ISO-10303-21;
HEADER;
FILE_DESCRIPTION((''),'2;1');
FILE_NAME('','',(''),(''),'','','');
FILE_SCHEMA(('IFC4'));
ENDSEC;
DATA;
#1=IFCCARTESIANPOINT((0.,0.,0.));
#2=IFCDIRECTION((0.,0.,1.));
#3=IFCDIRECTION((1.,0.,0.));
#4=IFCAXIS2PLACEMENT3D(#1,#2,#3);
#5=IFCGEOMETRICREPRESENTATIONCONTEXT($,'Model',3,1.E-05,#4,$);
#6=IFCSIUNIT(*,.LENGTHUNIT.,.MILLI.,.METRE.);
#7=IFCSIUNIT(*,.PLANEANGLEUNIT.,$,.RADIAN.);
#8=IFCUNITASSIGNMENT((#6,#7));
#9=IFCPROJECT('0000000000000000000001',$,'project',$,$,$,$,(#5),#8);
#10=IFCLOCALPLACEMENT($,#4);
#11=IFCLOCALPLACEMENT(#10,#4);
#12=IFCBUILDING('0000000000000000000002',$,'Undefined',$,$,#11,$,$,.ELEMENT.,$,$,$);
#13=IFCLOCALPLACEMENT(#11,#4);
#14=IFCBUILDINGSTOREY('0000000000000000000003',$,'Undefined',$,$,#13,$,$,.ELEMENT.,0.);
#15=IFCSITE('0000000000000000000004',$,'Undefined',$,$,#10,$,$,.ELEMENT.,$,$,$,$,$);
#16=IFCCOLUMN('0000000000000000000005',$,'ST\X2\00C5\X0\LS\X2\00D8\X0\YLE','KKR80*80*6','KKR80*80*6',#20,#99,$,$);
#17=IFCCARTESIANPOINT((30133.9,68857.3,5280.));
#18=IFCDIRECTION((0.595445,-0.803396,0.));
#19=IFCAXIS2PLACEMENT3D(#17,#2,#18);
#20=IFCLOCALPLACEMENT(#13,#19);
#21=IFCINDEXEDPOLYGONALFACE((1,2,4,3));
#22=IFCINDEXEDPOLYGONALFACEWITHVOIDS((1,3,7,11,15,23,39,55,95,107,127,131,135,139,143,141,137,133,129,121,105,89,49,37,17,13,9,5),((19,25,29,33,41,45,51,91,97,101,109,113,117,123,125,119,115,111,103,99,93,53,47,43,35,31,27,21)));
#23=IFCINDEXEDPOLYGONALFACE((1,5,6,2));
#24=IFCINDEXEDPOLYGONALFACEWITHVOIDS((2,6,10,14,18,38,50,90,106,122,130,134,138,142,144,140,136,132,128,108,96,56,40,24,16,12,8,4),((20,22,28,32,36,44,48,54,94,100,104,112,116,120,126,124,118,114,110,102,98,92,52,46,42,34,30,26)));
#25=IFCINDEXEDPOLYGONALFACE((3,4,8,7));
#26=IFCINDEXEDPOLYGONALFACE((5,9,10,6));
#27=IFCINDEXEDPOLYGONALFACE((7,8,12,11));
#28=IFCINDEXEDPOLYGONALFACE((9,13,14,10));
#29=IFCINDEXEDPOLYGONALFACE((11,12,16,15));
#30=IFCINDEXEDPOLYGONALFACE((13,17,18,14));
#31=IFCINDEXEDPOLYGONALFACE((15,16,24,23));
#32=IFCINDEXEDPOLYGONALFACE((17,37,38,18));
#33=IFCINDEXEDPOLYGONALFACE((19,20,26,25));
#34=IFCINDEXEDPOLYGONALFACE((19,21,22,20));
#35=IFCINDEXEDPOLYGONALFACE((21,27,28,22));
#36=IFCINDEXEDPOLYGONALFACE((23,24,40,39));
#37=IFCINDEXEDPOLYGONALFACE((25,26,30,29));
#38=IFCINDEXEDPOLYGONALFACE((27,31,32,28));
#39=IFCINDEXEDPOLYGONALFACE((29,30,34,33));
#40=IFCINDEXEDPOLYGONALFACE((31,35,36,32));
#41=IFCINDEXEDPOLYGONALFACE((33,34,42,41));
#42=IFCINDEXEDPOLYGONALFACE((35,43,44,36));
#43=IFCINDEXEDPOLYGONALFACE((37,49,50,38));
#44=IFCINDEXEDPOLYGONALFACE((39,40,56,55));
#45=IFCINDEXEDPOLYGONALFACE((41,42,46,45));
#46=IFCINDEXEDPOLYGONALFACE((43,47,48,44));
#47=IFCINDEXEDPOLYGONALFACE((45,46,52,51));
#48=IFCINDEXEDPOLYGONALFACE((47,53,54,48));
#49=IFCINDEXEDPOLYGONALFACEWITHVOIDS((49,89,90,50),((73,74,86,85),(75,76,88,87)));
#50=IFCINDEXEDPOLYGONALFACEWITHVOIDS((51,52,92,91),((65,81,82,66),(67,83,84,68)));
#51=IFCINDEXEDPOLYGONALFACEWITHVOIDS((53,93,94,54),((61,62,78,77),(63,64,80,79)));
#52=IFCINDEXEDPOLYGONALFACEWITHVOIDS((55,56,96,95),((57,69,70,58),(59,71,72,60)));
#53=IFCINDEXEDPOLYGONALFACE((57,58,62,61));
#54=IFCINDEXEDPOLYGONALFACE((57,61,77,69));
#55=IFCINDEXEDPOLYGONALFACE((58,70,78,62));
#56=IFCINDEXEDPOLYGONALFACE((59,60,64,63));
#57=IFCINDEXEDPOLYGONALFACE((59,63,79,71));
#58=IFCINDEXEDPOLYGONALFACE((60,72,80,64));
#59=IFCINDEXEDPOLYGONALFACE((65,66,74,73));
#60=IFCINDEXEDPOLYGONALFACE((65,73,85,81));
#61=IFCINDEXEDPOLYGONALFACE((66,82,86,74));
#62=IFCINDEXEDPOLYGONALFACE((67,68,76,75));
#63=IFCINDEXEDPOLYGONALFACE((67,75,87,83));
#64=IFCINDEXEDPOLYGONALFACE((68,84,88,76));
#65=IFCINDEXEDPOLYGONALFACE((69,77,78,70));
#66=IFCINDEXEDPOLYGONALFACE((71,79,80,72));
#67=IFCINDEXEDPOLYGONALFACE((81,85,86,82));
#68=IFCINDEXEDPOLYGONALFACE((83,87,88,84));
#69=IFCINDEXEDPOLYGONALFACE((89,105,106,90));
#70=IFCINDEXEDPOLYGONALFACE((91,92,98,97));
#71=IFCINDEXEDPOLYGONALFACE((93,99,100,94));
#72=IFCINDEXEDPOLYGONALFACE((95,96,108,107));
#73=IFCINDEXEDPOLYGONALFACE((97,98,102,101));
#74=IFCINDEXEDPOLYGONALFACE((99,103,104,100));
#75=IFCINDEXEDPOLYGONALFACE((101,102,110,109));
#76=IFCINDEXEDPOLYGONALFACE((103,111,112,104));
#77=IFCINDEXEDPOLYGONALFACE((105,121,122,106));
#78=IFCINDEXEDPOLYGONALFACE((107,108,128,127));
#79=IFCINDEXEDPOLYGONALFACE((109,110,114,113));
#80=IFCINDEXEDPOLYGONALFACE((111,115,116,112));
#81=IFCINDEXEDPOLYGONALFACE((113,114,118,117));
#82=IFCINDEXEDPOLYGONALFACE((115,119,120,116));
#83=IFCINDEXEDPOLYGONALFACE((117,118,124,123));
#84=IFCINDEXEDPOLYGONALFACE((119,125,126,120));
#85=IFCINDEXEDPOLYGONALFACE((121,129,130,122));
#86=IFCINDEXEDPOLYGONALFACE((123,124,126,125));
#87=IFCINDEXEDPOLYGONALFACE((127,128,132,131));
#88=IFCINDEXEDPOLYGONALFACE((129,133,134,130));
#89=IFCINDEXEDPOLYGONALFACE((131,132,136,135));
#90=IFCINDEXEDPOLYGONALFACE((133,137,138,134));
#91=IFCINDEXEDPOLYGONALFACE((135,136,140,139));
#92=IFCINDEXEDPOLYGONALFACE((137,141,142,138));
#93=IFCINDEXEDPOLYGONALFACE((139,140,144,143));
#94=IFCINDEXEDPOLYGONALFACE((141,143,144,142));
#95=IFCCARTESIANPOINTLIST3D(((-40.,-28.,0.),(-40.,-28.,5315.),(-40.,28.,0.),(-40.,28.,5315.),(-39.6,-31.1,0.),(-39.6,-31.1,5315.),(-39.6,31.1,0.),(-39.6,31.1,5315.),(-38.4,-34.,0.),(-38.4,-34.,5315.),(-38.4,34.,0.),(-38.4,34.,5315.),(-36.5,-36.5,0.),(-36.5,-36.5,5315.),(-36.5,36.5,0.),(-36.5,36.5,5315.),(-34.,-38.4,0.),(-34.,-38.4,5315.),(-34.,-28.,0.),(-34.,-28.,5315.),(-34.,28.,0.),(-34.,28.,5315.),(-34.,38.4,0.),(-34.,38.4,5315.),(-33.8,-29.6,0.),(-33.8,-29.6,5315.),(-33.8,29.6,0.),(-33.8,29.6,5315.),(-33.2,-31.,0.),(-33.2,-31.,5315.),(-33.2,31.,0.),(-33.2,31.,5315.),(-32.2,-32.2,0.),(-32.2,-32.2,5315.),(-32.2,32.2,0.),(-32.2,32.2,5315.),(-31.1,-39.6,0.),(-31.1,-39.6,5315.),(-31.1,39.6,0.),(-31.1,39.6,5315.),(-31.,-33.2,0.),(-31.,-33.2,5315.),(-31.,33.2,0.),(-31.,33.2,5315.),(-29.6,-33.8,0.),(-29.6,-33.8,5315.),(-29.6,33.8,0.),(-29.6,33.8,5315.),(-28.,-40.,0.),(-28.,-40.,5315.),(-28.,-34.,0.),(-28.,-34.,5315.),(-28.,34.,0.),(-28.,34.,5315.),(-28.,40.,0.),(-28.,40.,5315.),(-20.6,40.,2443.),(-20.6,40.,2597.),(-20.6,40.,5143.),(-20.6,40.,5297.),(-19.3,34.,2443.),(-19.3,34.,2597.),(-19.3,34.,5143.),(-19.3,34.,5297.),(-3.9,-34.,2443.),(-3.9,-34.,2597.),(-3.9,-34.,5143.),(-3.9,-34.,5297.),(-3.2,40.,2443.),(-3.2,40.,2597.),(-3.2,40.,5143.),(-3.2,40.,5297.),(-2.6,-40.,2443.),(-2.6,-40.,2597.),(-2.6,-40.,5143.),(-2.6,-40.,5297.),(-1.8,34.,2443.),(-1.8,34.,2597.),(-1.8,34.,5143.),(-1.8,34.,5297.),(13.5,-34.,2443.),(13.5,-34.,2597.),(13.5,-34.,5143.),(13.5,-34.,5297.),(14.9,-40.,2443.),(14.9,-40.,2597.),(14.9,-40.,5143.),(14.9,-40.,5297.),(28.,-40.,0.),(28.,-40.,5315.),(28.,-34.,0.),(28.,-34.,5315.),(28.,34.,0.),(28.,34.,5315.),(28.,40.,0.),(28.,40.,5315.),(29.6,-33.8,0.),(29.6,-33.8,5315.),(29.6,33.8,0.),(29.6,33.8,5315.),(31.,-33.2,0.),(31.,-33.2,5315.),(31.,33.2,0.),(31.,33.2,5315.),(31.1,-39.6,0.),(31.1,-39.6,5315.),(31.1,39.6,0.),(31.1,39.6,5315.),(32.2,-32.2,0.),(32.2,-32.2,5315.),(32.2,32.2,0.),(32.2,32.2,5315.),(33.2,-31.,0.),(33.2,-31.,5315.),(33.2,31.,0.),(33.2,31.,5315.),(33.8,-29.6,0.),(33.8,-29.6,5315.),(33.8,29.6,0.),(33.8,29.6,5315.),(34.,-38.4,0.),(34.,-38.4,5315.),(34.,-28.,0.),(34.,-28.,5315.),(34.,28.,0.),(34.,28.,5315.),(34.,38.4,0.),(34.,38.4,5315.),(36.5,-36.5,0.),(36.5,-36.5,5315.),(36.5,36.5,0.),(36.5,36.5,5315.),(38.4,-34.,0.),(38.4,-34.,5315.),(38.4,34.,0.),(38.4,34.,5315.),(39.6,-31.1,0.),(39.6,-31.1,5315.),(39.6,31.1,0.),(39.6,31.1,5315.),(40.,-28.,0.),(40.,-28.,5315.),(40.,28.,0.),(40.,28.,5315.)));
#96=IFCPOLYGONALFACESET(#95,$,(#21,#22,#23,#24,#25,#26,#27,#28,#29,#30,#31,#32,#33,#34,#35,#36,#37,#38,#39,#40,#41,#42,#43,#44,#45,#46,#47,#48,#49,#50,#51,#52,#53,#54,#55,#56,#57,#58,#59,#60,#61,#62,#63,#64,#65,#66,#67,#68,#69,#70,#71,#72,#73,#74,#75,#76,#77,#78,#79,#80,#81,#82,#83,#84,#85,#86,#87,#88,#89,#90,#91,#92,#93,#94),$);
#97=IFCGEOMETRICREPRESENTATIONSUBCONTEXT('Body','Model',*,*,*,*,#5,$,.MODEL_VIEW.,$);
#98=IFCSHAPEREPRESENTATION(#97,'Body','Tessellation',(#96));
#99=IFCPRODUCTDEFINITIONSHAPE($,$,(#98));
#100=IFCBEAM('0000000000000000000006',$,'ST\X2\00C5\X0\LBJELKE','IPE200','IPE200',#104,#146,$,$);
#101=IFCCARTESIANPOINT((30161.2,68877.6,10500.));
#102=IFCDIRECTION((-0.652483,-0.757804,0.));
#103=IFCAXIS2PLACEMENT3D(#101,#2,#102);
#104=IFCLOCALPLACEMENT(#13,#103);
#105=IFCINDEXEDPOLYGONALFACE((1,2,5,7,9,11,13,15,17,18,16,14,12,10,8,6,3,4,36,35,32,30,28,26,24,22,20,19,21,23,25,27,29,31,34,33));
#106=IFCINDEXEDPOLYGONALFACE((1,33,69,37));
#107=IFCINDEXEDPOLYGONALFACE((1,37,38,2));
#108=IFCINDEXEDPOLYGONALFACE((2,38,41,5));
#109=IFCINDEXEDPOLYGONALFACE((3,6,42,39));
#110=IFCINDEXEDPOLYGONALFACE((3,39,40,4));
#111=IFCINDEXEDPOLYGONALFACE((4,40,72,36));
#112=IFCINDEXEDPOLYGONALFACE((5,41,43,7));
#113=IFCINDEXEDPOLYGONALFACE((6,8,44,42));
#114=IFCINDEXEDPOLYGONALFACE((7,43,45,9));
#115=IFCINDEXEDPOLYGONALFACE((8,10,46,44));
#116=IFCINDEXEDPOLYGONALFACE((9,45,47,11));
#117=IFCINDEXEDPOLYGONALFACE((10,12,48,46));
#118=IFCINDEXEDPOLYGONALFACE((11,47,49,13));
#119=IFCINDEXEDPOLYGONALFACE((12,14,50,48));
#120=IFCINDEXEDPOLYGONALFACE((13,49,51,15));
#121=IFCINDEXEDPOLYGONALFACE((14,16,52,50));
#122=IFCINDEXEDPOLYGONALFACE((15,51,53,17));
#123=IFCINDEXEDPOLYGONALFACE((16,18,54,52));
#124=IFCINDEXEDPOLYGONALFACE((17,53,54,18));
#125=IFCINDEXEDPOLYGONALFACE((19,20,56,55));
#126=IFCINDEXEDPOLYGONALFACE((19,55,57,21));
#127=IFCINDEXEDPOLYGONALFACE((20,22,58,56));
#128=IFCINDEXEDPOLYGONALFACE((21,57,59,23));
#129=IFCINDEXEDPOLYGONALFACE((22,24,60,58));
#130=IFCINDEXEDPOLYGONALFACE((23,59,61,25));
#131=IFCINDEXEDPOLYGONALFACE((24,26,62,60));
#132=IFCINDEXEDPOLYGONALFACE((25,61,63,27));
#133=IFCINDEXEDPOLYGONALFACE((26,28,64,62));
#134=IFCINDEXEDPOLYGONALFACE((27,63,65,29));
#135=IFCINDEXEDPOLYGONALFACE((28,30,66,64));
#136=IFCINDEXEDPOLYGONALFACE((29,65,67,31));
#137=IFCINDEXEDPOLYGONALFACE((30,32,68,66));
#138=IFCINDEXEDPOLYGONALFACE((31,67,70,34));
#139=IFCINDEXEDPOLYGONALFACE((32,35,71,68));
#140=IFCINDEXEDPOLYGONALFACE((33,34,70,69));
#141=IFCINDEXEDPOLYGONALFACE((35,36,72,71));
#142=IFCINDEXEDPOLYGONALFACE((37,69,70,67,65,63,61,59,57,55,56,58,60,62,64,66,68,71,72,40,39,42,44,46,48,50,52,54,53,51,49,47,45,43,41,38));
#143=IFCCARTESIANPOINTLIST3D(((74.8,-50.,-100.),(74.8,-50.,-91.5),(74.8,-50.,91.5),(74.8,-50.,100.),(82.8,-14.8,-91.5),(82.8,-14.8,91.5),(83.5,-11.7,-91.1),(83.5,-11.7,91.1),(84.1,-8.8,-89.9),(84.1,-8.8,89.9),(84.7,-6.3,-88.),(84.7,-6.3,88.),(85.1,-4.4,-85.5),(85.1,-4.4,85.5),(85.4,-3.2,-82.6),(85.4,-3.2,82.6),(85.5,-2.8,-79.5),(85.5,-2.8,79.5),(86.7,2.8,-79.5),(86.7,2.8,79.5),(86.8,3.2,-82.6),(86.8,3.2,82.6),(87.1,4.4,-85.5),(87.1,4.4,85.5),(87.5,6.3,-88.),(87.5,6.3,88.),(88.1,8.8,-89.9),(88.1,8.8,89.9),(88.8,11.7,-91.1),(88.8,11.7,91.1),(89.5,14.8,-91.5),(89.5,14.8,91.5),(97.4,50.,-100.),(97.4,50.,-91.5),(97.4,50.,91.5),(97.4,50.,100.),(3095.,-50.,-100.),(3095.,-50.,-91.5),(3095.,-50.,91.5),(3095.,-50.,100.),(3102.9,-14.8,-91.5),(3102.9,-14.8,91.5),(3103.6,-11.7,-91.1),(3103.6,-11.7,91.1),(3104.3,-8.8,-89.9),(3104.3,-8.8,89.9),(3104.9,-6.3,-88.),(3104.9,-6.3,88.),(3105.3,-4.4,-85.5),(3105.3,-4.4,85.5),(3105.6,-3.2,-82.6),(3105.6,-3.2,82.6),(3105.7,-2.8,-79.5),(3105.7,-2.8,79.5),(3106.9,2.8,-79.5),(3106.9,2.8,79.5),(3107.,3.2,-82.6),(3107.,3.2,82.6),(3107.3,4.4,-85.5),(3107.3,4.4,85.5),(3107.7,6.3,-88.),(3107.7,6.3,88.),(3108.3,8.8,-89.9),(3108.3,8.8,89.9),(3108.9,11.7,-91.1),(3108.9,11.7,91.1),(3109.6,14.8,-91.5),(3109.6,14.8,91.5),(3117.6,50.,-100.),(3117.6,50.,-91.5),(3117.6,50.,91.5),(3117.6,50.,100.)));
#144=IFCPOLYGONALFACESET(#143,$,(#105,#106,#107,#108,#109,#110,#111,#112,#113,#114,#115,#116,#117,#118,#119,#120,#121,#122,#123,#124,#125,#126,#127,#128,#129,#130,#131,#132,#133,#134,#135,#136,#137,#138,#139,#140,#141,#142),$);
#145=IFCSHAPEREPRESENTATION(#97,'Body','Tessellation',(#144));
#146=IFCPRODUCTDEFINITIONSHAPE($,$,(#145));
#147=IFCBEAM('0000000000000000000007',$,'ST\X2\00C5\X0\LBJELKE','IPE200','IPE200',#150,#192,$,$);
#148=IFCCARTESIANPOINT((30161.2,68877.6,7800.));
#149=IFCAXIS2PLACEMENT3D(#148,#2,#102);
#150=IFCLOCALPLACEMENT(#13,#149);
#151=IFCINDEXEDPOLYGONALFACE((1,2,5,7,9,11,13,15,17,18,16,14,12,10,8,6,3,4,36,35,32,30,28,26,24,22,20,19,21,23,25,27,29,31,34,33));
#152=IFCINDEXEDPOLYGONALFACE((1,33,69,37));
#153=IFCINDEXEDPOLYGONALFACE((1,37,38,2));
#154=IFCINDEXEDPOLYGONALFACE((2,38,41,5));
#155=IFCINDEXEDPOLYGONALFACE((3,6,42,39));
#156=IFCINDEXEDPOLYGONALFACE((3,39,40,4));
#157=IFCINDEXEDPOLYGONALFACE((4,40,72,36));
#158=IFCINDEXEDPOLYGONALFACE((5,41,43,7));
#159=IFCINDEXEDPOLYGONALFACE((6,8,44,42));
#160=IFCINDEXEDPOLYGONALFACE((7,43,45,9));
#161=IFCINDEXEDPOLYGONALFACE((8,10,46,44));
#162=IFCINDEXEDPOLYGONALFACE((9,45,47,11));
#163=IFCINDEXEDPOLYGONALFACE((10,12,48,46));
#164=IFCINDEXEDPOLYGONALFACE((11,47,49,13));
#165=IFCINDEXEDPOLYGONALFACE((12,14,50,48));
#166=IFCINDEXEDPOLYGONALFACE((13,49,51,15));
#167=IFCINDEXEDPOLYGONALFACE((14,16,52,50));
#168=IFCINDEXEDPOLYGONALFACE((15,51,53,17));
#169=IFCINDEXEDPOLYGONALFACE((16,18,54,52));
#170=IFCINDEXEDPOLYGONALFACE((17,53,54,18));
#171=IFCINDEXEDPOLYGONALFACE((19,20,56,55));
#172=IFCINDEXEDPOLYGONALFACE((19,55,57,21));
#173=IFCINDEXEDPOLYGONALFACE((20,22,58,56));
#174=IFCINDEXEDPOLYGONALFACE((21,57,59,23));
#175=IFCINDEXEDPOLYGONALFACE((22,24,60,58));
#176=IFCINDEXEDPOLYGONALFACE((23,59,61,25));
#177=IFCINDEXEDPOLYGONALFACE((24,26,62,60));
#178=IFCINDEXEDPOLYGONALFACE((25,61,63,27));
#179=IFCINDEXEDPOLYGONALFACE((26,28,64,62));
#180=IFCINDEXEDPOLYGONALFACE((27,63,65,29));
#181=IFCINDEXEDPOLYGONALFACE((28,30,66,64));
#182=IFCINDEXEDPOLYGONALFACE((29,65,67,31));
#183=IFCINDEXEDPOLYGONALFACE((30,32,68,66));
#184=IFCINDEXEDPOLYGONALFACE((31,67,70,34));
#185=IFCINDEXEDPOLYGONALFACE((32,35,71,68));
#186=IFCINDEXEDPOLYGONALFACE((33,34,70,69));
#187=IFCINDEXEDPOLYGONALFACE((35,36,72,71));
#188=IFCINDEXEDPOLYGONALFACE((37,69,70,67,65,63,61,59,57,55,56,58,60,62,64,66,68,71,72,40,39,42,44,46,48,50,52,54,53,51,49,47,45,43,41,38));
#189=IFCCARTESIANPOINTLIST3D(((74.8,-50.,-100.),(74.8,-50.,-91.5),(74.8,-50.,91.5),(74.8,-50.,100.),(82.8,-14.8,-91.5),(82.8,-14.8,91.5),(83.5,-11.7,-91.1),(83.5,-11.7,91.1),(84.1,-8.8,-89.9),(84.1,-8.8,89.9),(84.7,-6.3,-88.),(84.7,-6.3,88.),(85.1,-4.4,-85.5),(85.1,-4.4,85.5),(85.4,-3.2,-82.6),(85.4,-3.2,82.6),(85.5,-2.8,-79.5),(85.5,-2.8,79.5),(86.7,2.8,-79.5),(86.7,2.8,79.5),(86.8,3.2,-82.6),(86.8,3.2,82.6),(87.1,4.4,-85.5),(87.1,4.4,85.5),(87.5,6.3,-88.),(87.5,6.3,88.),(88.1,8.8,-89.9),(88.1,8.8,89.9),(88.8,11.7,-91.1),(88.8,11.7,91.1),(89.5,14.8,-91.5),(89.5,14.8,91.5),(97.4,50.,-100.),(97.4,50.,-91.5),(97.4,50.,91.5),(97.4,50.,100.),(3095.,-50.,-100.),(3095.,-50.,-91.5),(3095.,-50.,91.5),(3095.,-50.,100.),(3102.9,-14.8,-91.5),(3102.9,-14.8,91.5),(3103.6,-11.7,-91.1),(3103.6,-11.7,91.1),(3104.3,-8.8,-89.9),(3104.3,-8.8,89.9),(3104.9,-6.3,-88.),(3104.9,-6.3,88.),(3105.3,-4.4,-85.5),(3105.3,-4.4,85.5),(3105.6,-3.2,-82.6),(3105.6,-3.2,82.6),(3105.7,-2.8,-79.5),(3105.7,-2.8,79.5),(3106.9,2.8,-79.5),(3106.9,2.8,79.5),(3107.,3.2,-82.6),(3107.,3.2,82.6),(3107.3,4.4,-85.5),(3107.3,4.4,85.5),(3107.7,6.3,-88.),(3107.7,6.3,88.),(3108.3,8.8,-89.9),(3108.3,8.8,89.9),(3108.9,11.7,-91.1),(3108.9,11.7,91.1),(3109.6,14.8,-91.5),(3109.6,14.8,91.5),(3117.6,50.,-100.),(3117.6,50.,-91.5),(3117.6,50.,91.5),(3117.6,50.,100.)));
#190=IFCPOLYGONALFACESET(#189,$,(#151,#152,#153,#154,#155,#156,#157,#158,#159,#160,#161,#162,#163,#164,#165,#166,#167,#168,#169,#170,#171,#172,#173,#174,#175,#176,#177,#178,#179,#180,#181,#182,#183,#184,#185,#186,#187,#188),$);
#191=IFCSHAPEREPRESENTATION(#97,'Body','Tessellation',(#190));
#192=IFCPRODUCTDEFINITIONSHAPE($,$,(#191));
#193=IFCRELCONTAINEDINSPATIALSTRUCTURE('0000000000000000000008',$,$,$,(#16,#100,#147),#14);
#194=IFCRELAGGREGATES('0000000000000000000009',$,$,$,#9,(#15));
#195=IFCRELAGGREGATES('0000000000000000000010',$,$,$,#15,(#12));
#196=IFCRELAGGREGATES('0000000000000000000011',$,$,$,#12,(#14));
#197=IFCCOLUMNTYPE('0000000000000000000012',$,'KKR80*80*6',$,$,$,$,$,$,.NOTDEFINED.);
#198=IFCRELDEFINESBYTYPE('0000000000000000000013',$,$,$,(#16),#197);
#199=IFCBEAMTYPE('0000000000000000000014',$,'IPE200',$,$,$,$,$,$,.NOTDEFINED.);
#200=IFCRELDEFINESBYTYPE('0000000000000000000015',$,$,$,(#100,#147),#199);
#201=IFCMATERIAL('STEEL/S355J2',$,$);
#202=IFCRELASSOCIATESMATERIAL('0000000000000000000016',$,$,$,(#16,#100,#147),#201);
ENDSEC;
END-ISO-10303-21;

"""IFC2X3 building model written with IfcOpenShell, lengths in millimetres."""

from ifc_helpers import new_model, si_unit, frame, origin_with_axes, origin_2d_with_axis, place, context, subcontext, project, spatial, polyline, hollow_rectangle, i_section, outline, extrude, boolean, clip, halfspace, material, type_object, element, save


model = new_model("IFC2X3")

# Units and contexts
model_context = context("Model", 3, precision=1e-05, world=origin_with_axes())
body_context = subcontext(model_context, "Body", "Model", "MODEL_VIEW")
ifc_project = project(units=[si_unit("LENGTHUNIT", "METRE", prefix="MILLI"), si_unit("PLANEANGLEUNIT", "RADIAN")], contexts=[model_context])

# Site, building, storey
site_placement = place(None, origin_with_axes())
site = spatial("IfcSite", under=ifc_project, at=site_placement, Name="Undefined", CompositionType="ELEMENT")
building_placement = place(site_placement, origin_with_axes())
building = spatial("IfcBuilding", under=site, at=building_placement, Name="Undefined", CompositionType="ELEMENT")
storey_placement = place(building_placement, origin_with_axes())
storey = spatial("IfcBuildingStorey", under=building, at=storey_placement, Name="Undefined", CompositionType="ELEMENT", Elevation=0.0)

# Column
ifc_material_1 = material(Name="STEEL/S355J2")
column_type_1 = type_object("IfcColumnType", Name="KKR80*80*6", PredefinedType="NOTDEFINED")
column_placement = place(storey_placement, frame((30133.9, 68857.3, 5280.0), z_axis=(0.0, 0.0, 1.0), x_axis=(0.595445, -0.803396, 0.0)))
element("IfcColumn", 1, at=column_placement, inside=storey, type_object=column_type_1, material=ifc_material_1, Name="STÅLSØYLE", Description="KKR80*80*6", ObjectType="KKR80*80*6", context=body_context, shape_type="CSG", body=[
    boolean("DIFFERENCE", boolean("DIFFERENCE", boolean("DIFFERENCE", boolean("DIFFERENCE", boolean("DIFFERENCE", extrude(hollow_rectangle(XDim=80.0, YDim=80.0, WallThickness=6.0, InnerFilletRadius=6.0, OuterFilletRadius=12.0, at=origin_2d_with_axis()), frame((0.0, 0.0, 5315.0), z_axis=(0.0, 0.0, -1.0), x_axis=(0.0, 1.0, 0.0)), (0.0, 0.0, 1.0), 5315.0), extrude(outline(polyline([(0.0, 0.0), (17.0, 0.0), (17.0, 154.0), (0.0, 154.0), (0.0, 0.0)])), frame((-16.3, 20.9, 5297.0), z_axis=(-0.220299, 0.975432, 0.0), x_axis=(0.975432, 0.220299, 0.0)), (0.0, 0.0, 1.0), 26.0)), extrude(outline(polyline([(0.0, 0.0), (17.0, 0.0), (17.0, 154.0), (0.0, 154.0), (0.0, 0.0)])), frame((0.4, -53.3, 5297.0), z_axis=(-0.220299, 0.975432, 0.0), x_axis=(0.975432, 0.220299, 0.0)), (0.0, 0.0, 1.0), 26.0)), extrude(outline(polyline([(0.0, 0.0), (17.0, 0.0), (17.0, 154.0), (0.0, 154.0), (0.0, 0.0)])), frame((-16.3, 20.9, 2597.0), z_axis=(-0.220299, 0.975432, 0.0), x_axis=(0.975432, 0.220299, 0.0)), (0.0, 0.0, 1.0), 26.0)), extrude(outline(polyline([(0.0, 0.0), (17.0, 0.0), (17.0, 154.0), (0.0, 154.0), (0.0, 0.0)])), frame((0.4, -53.3, 2597.0), z_axis=(-0.220299, 0.975432, 0.0), x_axis=(0.975432, 0.220299, 0.0)), (0.0, 0.0, 1.0), 26.0)), halfspace(frame((-40.0, 0.0, 5315.0), z_axis=(0.0, 0.0, -1.0), x_axis=(0.0, -1.0, 0.0)), True)),
])

# Beams
beam_type_1 = type_object("IfcBeamType", Name="IPE200", PredefinedType="NOTDEFINED")
for number, where, z_axis, x_axis, name in (
    (2, (30161.2, 68877.6, 10500.0), (0.0, 0.0, 1.0), (-0.652483, -0.757804, 0.0), "STÅLBJELKE"),
    (3, (30161.2, 68877.6, 7800.0), (0.0, 0.0, 1.0), (-0.652483, -0.757804, 0.0), "STÅLBJELKE"),
):
    element("IfcBeam", number, at=place(storey_placement, frame(where, z_axis=z_axis, x_axis=x_axis)), inside=storey, type_object=beam_type_1, material=ifc_material_1, Name=name, Description="IPE200", ObjectType="IPE200", context=body_context, shape_type="Clipping", body=[
        clip(clip(extrude(i_section(OverallWidth=100.0, OverallDepth=200.0, WebThickness=5.6, FlangeThickness=8.5, FilletRadius=12.0, at=origin_2d_with_axis()), frame((3298.9, 0.0, 0.0), z_axis=(-1.0, 0.0, 0.0), x_axis=(0.0, -1.0, 0.0)), (0.0, 0.0, 1.0), 3298.9), halfspace(frame((3095.5, -47.8, -100.0), z_axis=(0.975432, -0.220299, 0.0), x_axis=(0.0, 0.0, 1.0)), False)), halfspace(frame((96.9, 47.8, -100.0), z_axis=(-0.975432, 0.220299, 0.0), x_axis=(0.0, 0.0, 1.0)), False)),
    ])

save(model, "model.ifc")
